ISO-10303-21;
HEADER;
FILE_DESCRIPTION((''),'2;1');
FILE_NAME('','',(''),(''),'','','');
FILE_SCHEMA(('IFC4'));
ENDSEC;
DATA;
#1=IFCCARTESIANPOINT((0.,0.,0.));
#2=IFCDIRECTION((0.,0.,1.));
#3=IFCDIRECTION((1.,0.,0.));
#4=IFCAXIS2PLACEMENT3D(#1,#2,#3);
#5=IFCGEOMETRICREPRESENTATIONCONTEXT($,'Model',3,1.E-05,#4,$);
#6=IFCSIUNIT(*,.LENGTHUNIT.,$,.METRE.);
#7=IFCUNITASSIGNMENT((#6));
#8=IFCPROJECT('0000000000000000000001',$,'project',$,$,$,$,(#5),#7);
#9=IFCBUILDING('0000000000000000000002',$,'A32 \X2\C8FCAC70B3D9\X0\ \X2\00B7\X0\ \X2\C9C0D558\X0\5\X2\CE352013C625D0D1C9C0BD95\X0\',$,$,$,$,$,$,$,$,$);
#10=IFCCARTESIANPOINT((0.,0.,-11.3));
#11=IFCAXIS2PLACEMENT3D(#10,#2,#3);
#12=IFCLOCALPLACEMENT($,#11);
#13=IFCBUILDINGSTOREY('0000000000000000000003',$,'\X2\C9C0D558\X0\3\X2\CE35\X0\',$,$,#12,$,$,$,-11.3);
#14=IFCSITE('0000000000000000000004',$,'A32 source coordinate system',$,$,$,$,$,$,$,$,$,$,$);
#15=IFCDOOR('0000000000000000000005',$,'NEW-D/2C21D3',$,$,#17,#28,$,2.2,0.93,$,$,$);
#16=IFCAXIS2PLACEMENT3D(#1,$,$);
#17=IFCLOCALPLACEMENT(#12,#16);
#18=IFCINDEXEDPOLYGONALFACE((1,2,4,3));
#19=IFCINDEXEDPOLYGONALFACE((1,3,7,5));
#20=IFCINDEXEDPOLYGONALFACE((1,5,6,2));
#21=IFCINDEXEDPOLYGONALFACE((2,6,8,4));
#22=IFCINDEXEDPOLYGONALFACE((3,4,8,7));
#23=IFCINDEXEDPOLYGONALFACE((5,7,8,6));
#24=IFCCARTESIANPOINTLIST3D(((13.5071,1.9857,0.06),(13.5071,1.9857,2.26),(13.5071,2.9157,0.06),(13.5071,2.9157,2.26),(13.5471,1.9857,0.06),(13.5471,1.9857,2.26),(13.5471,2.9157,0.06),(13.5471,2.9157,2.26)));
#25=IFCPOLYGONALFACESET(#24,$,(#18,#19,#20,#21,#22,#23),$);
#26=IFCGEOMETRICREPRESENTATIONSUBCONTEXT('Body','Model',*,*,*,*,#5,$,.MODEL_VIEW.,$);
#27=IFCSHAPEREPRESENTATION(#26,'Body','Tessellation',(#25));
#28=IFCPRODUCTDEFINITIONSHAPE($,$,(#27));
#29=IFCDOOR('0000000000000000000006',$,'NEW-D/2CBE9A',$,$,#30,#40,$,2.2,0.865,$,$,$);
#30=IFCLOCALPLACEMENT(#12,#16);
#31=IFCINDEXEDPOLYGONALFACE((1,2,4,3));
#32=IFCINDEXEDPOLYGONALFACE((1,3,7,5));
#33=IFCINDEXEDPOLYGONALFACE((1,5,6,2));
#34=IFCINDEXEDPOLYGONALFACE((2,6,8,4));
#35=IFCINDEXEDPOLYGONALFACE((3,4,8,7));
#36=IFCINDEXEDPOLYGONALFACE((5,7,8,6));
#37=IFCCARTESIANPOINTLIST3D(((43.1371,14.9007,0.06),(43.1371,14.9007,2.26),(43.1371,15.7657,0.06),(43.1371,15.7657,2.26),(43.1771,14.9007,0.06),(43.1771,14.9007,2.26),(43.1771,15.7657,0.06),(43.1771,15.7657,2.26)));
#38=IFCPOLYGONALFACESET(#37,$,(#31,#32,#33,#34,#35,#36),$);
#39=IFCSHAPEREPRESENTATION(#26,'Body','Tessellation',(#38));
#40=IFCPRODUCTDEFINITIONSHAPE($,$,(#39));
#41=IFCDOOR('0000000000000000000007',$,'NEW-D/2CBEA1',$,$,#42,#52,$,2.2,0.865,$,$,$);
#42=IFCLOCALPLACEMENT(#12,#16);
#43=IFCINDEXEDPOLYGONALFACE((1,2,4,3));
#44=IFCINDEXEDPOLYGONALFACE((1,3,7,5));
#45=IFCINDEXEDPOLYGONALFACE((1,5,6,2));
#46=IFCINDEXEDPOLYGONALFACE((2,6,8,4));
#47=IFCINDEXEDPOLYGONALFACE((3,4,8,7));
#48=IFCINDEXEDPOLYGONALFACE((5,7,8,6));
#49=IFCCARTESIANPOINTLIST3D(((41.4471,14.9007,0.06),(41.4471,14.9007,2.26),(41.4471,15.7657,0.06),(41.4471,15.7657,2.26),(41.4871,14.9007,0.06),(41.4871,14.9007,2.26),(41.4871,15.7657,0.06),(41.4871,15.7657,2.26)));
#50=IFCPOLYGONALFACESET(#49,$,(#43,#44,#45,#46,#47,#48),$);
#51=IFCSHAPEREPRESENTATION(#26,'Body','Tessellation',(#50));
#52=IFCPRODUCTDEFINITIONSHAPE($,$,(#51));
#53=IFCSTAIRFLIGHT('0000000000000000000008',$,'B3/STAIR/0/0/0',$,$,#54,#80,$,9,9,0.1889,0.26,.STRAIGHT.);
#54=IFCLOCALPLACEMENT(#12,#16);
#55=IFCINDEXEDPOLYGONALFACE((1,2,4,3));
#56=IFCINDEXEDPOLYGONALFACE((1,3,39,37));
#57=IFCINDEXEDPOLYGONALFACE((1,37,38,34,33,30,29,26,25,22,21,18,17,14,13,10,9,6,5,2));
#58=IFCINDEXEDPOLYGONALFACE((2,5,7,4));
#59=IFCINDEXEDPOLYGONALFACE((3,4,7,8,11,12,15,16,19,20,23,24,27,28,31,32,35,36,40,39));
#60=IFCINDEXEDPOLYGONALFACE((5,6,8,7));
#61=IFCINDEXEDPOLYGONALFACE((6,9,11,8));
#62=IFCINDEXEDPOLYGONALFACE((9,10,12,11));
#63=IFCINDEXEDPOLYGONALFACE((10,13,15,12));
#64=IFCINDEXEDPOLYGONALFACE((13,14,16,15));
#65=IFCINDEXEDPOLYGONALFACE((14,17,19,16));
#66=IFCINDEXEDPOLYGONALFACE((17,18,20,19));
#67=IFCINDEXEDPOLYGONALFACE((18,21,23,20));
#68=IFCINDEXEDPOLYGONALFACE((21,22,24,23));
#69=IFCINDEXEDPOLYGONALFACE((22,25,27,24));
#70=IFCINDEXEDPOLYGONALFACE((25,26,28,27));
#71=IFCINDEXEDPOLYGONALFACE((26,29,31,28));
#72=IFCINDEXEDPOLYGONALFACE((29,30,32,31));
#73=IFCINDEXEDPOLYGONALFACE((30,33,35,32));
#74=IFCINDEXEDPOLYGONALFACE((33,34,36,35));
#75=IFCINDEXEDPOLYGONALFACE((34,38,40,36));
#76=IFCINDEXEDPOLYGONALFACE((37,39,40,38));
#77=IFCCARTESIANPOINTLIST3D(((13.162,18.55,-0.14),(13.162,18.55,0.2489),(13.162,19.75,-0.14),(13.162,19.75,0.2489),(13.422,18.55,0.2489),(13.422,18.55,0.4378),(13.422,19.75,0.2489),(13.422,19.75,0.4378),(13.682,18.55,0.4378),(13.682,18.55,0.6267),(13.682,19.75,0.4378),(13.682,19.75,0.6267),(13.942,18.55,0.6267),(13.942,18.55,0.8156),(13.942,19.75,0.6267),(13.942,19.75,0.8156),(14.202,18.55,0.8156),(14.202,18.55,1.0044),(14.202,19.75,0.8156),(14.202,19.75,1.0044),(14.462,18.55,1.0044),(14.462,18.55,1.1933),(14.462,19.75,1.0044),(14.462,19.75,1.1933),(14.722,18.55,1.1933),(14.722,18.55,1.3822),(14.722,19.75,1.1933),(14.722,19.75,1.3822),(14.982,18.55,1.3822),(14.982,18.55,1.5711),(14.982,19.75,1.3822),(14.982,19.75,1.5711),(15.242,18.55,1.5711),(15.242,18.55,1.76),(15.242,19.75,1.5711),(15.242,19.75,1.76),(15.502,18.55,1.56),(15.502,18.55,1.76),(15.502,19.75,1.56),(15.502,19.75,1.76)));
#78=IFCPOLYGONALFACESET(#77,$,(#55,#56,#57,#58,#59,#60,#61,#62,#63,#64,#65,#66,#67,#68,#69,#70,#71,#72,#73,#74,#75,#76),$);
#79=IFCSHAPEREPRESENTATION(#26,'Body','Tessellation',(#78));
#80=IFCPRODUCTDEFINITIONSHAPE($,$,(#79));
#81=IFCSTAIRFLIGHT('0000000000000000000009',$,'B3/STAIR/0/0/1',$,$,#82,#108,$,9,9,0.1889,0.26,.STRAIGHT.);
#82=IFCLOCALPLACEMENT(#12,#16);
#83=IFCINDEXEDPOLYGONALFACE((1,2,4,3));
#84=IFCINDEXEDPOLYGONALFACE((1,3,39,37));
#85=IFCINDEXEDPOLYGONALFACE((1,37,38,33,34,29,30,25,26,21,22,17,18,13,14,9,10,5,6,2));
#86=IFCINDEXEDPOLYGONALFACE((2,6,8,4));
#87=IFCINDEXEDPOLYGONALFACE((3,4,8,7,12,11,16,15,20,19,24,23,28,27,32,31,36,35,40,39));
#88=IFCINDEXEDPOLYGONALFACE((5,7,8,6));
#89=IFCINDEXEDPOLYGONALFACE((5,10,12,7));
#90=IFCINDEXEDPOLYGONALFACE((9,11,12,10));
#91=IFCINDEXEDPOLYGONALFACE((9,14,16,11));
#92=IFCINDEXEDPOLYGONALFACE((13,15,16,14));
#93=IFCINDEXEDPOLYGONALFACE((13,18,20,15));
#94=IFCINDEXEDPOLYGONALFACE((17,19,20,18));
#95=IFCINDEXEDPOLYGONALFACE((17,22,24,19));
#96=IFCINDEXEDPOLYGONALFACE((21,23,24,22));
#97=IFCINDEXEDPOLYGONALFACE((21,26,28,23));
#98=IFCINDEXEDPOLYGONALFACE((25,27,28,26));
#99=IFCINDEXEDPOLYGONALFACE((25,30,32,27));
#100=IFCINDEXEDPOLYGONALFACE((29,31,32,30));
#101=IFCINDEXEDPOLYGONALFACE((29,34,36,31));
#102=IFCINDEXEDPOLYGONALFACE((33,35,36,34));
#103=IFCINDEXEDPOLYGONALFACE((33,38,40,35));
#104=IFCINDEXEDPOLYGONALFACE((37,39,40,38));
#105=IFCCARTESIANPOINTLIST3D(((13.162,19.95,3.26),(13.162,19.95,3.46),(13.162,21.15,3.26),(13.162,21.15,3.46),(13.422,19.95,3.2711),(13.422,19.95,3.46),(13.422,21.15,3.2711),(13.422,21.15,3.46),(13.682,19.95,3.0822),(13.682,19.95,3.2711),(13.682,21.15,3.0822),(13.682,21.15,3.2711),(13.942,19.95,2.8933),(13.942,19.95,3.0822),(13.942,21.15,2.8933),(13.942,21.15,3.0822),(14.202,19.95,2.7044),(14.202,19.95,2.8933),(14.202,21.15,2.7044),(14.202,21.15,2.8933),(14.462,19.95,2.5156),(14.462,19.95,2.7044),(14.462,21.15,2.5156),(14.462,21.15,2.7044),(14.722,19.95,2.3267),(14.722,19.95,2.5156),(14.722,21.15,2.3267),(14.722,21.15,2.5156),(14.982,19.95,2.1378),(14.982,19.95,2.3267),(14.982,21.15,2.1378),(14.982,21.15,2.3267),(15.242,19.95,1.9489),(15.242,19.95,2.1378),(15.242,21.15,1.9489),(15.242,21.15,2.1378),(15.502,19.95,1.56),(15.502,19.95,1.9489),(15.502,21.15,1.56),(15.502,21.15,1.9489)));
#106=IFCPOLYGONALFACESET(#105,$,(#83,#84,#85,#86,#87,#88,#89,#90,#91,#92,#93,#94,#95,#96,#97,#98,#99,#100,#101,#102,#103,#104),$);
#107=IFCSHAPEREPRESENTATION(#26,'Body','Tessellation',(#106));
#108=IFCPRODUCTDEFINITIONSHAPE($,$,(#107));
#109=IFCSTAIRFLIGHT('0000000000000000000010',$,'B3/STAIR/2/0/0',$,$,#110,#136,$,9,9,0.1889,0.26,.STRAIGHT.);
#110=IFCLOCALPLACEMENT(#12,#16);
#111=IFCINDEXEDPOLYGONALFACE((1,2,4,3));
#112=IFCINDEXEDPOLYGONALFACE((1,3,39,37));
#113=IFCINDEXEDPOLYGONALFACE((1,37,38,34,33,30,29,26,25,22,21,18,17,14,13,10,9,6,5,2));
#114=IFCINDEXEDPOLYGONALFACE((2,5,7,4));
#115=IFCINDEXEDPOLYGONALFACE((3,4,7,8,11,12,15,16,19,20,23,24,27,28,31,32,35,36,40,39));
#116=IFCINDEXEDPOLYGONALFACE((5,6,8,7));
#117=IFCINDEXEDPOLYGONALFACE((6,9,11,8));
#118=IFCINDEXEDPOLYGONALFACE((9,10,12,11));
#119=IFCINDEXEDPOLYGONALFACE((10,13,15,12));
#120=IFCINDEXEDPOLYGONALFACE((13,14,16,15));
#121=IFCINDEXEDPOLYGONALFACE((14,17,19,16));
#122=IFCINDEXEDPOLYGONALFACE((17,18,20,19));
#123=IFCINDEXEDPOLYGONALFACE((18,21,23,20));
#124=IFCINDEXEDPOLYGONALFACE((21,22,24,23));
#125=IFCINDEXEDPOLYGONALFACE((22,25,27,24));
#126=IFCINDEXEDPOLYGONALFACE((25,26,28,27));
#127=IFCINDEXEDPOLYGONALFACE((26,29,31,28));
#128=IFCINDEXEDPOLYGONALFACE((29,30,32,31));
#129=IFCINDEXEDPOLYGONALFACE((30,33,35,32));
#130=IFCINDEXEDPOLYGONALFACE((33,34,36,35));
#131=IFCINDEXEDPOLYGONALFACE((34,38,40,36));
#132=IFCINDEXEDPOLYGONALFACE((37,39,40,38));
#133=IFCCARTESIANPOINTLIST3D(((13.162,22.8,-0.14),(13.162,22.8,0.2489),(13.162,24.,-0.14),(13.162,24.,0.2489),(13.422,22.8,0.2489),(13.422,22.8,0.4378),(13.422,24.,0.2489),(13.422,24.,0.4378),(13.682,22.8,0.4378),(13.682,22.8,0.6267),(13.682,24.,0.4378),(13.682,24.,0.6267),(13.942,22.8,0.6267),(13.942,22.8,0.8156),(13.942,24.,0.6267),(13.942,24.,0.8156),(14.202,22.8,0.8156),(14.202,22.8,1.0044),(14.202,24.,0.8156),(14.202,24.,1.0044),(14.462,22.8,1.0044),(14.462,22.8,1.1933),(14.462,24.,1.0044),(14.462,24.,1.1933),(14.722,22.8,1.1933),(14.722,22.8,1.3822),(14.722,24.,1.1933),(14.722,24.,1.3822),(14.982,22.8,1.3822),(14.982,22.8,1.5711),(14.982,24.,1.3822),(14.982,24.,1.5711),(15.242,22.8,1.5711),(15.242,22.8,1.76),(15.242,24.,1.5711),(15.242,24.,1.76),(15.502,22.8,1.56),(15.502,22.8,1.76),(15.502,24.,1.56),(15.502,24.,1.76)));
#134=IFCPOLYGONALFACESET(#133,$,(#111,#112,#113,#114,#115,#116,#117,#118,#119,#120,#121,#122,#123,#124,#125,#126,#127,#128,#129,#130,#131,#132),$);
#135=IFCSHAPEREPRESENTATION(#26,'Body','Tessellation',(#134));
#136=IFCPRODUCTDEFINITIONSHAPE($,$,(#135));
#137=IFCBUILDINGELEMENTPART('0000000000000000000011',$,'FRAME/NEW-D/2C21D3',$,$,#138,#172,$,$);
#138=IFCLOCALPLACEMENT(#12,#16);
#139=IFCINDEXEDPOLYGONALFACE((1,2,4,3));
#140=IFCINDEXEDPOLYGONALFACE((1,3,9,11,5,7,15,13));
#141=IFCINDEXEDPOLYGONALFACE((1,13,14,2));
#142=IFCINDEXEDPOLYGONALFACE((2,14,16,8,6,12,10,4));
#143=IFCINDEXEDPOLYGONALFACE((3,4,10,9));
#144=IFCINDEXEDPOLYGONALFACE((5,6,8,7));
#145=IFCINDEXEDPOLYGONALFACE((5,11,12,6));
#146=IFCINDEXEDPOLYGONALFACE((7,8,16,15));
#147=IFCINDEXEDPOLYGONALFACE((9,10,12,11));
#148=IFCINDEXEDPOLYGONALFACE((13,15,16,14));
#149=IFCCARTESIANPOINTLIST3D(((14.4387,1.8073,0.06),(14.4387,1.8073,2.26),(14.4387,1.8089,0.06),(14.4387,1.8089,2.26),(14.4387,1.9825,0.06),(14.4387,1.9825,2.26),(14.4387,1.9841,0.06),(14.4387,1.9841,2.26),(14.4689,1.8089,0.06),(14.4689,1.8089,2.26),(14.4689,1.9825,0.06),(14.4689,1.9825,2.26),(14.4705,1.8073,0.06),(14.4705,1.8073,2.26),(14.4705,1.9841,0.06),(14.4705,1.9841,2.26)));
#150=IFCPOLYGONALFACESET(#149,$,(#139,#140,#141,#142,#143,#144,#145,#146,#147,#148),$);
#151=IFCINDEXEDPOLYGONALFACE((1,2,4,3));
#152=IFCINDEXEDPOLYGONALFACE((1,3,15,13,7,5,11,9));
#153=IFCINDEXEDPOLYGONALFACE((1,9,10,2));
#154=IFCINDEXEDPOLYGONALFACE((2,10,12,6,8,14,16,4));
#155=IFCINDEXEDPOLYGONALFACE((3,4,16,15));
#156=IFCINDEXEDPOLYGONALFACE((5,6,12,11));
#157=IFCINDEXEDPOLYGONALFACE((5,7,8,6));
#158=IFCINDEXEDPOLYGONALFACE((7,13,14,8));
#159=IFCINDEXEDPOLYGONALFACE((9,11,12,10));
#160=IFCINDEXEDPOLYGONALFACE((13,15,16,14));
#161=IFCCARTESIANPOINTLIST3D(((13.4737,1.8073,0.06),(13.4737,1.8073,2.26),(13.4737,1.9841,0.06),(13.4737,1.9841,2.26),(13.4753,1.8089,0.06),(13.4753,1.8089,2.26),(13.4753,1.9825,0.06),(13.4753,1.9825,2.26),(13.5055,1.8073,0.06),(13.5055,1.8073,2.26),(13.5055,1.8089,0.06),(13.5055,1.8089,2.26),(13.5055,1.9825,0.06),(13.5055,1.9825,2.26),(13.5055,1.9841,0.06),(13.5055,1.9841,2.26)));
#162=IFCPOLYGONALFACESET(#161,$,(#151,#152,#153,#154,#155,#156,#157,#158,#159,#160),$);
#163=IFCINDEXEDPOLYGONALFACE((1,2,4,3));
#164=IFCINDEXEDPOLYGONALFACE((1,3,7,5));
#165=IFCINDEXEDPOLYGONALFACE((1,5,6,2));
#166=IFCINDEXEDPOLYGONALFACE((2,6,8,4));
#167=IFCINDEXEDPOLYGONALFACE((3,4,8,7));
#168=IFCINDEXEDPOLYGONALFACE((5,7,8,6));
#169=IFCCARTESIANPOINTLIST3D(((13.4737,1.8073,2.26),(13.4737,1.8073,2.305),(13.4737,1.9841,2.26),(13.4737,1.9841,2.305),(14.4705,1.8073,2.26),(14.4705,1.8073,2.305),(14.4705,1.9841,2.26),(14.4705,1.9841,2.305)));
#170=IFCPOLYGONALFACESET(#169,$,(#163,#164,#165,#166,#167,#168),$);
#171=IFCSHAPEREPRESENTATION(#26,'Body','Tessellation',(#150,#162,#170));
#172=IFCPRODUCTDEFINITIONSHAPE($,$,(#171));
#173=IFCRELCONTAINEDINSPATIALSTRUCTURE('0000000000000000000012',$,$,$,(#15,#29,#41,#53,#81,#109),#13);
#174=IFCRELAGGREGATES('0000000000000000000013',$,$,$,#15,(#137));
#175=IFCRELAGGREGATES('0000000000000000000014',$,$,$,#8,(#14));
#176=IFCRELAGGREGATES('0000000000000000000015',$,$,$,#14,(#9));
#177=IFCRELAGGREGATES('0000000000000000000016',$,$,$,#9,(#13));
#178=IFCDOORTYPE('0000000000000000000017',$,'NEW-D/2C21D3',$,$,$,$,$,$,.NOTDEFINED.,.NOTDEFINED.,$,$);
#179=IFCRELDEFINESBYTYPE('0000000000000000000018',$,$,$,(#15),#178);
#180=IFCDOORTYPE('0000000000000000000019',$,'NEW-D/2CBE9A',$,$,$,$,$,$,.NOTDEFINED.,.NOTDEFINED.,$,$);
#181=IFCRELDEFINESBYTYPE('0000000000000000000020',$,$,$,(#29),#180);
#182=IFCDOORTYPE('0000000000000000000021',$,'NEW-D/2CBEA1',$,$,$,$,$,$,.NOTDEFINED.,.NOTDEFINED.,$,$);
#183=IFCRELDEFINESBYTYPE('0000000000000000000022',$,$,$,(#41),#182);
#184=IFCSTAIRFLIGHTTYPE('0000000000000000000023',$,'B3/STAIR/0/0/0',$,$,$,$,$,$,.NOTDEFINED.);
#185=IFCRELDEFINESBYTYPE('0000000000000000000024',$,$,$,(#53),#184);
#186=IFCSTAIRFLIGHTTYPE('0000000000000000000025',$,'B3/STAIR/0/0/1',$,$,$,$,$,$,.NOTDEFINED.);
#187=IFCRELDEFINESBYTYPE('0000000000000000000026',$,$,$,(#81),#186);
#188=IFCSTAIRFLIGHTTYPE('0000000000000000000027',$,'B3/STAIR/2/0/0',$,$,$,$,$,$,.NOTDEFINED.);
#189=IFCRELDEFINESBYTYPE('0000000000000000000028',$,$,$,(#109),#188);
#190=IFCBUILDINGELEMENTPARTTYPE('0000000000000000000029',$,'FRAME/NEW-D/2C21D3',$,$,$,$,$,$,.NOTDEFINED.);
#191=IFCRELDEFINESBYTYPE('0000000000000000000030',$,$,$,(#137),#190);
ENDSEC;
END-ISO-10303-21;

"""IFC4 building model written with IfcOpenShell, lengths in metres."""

from ifc_helpers import new_model, si_unit, frame, origin, origin_with_axes, place, context, subcontext, project, spatial, polyline, outline, extrude, source, transform, mapped, type_object, type_shapes, element, aggregate, save


model = new_model("IFC4")

# Units and contexts
model_context = context("Model", 3, precision=1e-05, world=origin_with_axes())
body_context = subcontext(model_context, "Body", "Model", "MODEL_VIEW")
ifc_project = project(units=[si_unit("LENGTHUNIT", "METRE")], contexts=[model_context])

# Site, building, storey
site = spatial("IfcSite", under=ifc_project, Name="A32 source coordinate system")
building = spatial("IfcBuilding", under=site, Name="A32 주거동 · 지하5층–옥탑지붕")
storey_placement = place(None, frame((0.0, 0.0, -11.3), z_axis=(0.0, 0.0, 1.0), x_axis=(1.0, 0.0, 0.0)))
storey = spatial("IfcBuildingStorey", under=building, at=storey_placement, Name="지하3층", Elevation=-11.3)

# Door
door_type_1 = type_object("IfcDoorType", Name="NEW-D/2C21D3", OperationType="NOTDEFINED", PredefinedType="NOTDEFINED")
shared_shape_1 = source(origin(), body_context, "Body", "SweptSolid", [
    extrude(outline(polyline([(13.5471, 2.9157), (13.5471, 1.9857), (13.5071, 1.9857), (13.5071, 2.9157), (13.5471, 2.9157)])), frame((0.0, 0.0, 0.06)), (0.0, 0.0, 1.0), 2.2),
])
type_shapes(door_type_1, [shared_shape_1])
door_1_placement = place(storey_placement, origin_with_axes())
door_1 = element("IfcDoor", 1, at=door_1_placement, inside=storey, type_object=door_type_1, Name="NEW-D/2C21D3", OverallHeight=2.2, OverallWidth=0.93, context=body_context, shape_type="MappedRepresentation", body=[
    mapped(shared_shape_1, transform((0.0, 0.0, 0.0), scale=1.0)),
])

# Doors
door_type_2 = type_object("IfcDoorType", Name="NEW-D/2CBE9A", OperationType="NOTDEFINED", PredefinedType="NOTDEFINED")
shared_shape_2 = source(origin(), body_context, "Body", "SweptSolid", [
    extrude(outline(polyline([(43.1771, 15.7657), (43.1771, 14.9007), (43.1371, 14.9007), (43.1371, 15.7657), (43.1771, 15.7657)])), frame((0.0, 0.0, 0.06)), (0.0, 0.0, 1.0), 2.2),
])
type_shapes(door_type_2, [shared_shape_2])
door_2_placement = place(storey_placement, origin_with_axes())
element("IfcDoor", 2, at=door_2_placement, inside=storey, type_object=door_type_2, Name="NEW-D/2CBE9A", OverallHeight=2.2, OverallWidth=0.865, context=body_context, shape_type="MappedRepresentation", body=[
    mapped(shared_shape_2, transform((0.0, 0.0, 0.0), scale=1.0)),
])
door_type_3 = type_object("IfcDoorType", Name="NEW-D/2CBEA1", OperationType="NOTDEFINED", PredefinedType="NOTDEFINED")
shared_shape_3 = source(origin(), body_context, "Body", "SweptSolid", [
    extrude(outline(polyline([(41.4871, 14.9007), (41.4471, 14.9007), (41.4471, 15.7657), (41.4871, 15.7657), (41.4871, 14.9007)])), frame((0.0, 0.0, 0.06)), (0.0, 0.0, 1.0), 2.2),
])
type_shapes(door_type_3, [shared_shape_3])
door_3_placement = place(storey_placement, origin_with_axes())
element("IfcDoor", 3, at=door_3_placement, inside=storey, type_object=door_type_3, Name="NEW-D/2CBEA1", OverallHeight=2.2, OverallWidth=0.865, context=body_context, shape_type="MappedRepresentation", body=[
    mapped(shared_shape_3, transform((0.0, 0.0, 0.0), scale=1.0)),
])

# Stair flights
stair_flight_type_1 = type_object("IfcStairFlightType", Name="B3/STAIR/0/0/0", PredefinedType="NOTDEFINED")
shared_shape_4 = source(origin(), body_context, "Body", "SweptSolid", [
    extrude(outline(polyline([(0.0, -0.14), (2.34, 1.56), (2.34, 1.76), (2.08, 1.76), (2.08, 1.5711), (1.82, 1.5711), (1.82, 1.3822), (1.56, 1.3822), (1.56, 1.1933), (1.3, 1.1933), (1.3, 1.0044), (1.04, 1.0044), (1.04, 0.8156), (0.78, 0.8156), (0.78, 0.6267), (0.52, 0.6267), (0.52, 0.4378), (0.26, 0.4378), (0.26, 0.2489), (0.0, 0.2489), (0.0, -0.14)])), frame((13.162, 19.75, 0.0), z_axis=(0.0, -1.0, 0.0), x_axis=(1.0, 0.0, 0.0)), (0.0, 0.0, 1.0), 1.2),
])
type_shapes(stair_flight_type_1, [shared_shape_4])
stair_flight_1_placement = place(storey_placement, origin_with_axes())
element("IfcStairFlight", 4, at=stair_flight_1_placement, inside=storey, type_object=stair_flight_type_1, Name="B3/STAIR/0/0/0", NumberOfRisers=9, NumberOfTreads=9, PredefinedType="STRAIGHT", RiserHeight=0.1889, TreadLength=0.26, context=body_context, shape_type="MappedRepresentation", body=[
    mapped(shared_shape_4, transform((0.0, 0.0, 0.0), scale=1.0)),
])
stair_flight_type_2 = type_object("IfcStairFlightType", Name="B3/STAIR/0/0/1", PredefinedType="NOTDEFINED")
shared_shape_5 = source(origin(), body_context, "Body", "SweptSolid", [
    extrude(outline(polyline([(0.0, 1.56), (2.34, 3.26), (2.34, 3.46), (2.08, 3.46), (2.08, 3.2711), (1.82, 3.2711), (1.82, 3.0822), (1.56, 3.0822), (1.56, 2.8933), (1.3, 2.8933), (1.3, 2.7044), (1.04, 2.7044), (1.04, 2.5156), (0.78, 2.5156), (0.78, 2.3267), (0.52, 2.3267), (0.52, 2.1378), (0.26, 2.1378), (0.26, 1.9489), (0.0, 1.9489), (0.0, 1.56)])), frame((15.502, 19.95, 0.0), z_axis=(0.0, 1.0, 0.0), x_axis=(-1.0, 0.0, 0.0)), (0.0, 0.0, 1.0), 1.2),
])
type_shapes(stair_flight_type_2, [shared_shape_5])
stair_flight_2_placement = place(storey_placement, origin_with_axes())
element("IfcStairFlight", 5, at=stair_flight_2_placement, inside=storey, type_object=stair_flight_type_2, Name="B3/STAIR/0/0/1", NumberOfRisers=9, NumberOfTreads=9, PredefinedType="STRAIGHT", RiserHeight=0.1889, TreadLength=0.26, context=body_context, shape_type="MappedRepresentation", body=[
    mapped(shared_shape_5, transform((0.0, 0.0, 0.0), scale=1.0)),
])
stair_flight_type_3 = type_object("IfcStairFlightType", Name="B3/STAIR/2/0/0", PredefinedType="NOTDEFINED")
shared_shape_6 = source(origin(), body_context, "Body", "SweptSolid", [
    extrude(outline(polyline([(0.0, -0.14), (2.34, 1.56), (2.34, 1.76), (2.08, 1.76), (2.08, 1.5711), (1.82, 1.5711), (1.82, 1.3822), (1.56, 1.3822), (1.56, 1.1933), (1.3, 1.1933), (1.3, 1.0044), (1.04, 1.0044), (1.04, 0.8156), (0.78, 0.8156), (0.78, 0.6267), (0.52, 0.6267), (0.52, 0.4378), (0.26, 0.4378), (0.26, 0.2489), (0.0, 0.2489), (0.0, -0.14)])), frame((13.162, 24.0, 0.0), z_axis=(0.0, -1.0, 0.0), x_axis=(1.0, 0.0, 0.0)), (0.0, 0.0, 1.0), 1.2),
])
type_shapes(stair_flight_type_3, [shared_shape_6])
stair_flight_3_placement = place(storey_placement, origin_with_axes())
element("IfcStairFlight", 6, at=stair_flight_3_placement, inside=storey, type_object=stair_flight_type_3, Name="B3/STAIR/2/0/0", NumberOfRisers=9, NumberOfTreads=9, PredefinedType="STRAIGHT", RiserHeight=0.1889, TreadLength=0.26, context=body_context, shape_type="MappedRepresentation", body=[
    mapped(shared_shape_6, transform((0.0, 0.0, 0.0), scale=1.0)),
])

# Building element part
building_element_part_type_1 = type_object("IfcBuildingElementPartType", Name="FRAME/NEW-D/2C21D3", PredefinedType="NOTDEFINED")
shared_shape_7 = source(origin(), body_context, "Body", "SweptSolid", [
    extrude(outline(polyline([(14.4705, 1.8073), (14.4387, 1.8073), (14.4387, 1.8089), (14.4689, 1.8089), (14.4689, 1.9825), (14.4387, 1.9825), (14.4387, 1.9841), (14.4705, 1.9841), (14.4705, 1.8073)])), frame((0.0, 0.0, 0.06)), (0.0, 0.0, 1.0), 2.2),
    extrude(outline(polyline([(13.4753, 1.9825), (13.4753, 1.8089), (13.5055, 1.8089), (13.5055, 1.8073), (13.4737, 1.8073), (13.4737, 1.9841), (13.5055, 1.9841), (13.5055, 1.9825), (13.4753, 1.9825)])), frame((0.0, 0.0, 0.06)), (0.0, 0.0, 1.0), 2.2),
    extrude(outline(polyline([(14.4705, 1.8073), (14.4705, 1.9841), (13.4737, 1.9841), (13.4737, 1.8073), (14.4705, 1.8073)])), frame((0.0, 0.0, 2.26)), (0.0, 0.0, 1.0), 0.045),
])
type_shapes(building_element_part_type_1, [shared_shape_7])
building_element_part_1_placement = place(door_1_placement, origin_with_axes())
building_element_part_1 = element("IfcBuildingElementPart", 7, at=building_element_part_1_placement, type_object=building_element_part_type_1, Name="FRAME/NEW-D/2C21D3", context=body_context, shape_type="MappedRepresentation", body=[
    mapped(shared_shape_7, transform((0.0, 0.0, 0.0), scale=1.0)),
])
aggregate(door_1, [building_element_part_1])

save(model, "model.ifc")
